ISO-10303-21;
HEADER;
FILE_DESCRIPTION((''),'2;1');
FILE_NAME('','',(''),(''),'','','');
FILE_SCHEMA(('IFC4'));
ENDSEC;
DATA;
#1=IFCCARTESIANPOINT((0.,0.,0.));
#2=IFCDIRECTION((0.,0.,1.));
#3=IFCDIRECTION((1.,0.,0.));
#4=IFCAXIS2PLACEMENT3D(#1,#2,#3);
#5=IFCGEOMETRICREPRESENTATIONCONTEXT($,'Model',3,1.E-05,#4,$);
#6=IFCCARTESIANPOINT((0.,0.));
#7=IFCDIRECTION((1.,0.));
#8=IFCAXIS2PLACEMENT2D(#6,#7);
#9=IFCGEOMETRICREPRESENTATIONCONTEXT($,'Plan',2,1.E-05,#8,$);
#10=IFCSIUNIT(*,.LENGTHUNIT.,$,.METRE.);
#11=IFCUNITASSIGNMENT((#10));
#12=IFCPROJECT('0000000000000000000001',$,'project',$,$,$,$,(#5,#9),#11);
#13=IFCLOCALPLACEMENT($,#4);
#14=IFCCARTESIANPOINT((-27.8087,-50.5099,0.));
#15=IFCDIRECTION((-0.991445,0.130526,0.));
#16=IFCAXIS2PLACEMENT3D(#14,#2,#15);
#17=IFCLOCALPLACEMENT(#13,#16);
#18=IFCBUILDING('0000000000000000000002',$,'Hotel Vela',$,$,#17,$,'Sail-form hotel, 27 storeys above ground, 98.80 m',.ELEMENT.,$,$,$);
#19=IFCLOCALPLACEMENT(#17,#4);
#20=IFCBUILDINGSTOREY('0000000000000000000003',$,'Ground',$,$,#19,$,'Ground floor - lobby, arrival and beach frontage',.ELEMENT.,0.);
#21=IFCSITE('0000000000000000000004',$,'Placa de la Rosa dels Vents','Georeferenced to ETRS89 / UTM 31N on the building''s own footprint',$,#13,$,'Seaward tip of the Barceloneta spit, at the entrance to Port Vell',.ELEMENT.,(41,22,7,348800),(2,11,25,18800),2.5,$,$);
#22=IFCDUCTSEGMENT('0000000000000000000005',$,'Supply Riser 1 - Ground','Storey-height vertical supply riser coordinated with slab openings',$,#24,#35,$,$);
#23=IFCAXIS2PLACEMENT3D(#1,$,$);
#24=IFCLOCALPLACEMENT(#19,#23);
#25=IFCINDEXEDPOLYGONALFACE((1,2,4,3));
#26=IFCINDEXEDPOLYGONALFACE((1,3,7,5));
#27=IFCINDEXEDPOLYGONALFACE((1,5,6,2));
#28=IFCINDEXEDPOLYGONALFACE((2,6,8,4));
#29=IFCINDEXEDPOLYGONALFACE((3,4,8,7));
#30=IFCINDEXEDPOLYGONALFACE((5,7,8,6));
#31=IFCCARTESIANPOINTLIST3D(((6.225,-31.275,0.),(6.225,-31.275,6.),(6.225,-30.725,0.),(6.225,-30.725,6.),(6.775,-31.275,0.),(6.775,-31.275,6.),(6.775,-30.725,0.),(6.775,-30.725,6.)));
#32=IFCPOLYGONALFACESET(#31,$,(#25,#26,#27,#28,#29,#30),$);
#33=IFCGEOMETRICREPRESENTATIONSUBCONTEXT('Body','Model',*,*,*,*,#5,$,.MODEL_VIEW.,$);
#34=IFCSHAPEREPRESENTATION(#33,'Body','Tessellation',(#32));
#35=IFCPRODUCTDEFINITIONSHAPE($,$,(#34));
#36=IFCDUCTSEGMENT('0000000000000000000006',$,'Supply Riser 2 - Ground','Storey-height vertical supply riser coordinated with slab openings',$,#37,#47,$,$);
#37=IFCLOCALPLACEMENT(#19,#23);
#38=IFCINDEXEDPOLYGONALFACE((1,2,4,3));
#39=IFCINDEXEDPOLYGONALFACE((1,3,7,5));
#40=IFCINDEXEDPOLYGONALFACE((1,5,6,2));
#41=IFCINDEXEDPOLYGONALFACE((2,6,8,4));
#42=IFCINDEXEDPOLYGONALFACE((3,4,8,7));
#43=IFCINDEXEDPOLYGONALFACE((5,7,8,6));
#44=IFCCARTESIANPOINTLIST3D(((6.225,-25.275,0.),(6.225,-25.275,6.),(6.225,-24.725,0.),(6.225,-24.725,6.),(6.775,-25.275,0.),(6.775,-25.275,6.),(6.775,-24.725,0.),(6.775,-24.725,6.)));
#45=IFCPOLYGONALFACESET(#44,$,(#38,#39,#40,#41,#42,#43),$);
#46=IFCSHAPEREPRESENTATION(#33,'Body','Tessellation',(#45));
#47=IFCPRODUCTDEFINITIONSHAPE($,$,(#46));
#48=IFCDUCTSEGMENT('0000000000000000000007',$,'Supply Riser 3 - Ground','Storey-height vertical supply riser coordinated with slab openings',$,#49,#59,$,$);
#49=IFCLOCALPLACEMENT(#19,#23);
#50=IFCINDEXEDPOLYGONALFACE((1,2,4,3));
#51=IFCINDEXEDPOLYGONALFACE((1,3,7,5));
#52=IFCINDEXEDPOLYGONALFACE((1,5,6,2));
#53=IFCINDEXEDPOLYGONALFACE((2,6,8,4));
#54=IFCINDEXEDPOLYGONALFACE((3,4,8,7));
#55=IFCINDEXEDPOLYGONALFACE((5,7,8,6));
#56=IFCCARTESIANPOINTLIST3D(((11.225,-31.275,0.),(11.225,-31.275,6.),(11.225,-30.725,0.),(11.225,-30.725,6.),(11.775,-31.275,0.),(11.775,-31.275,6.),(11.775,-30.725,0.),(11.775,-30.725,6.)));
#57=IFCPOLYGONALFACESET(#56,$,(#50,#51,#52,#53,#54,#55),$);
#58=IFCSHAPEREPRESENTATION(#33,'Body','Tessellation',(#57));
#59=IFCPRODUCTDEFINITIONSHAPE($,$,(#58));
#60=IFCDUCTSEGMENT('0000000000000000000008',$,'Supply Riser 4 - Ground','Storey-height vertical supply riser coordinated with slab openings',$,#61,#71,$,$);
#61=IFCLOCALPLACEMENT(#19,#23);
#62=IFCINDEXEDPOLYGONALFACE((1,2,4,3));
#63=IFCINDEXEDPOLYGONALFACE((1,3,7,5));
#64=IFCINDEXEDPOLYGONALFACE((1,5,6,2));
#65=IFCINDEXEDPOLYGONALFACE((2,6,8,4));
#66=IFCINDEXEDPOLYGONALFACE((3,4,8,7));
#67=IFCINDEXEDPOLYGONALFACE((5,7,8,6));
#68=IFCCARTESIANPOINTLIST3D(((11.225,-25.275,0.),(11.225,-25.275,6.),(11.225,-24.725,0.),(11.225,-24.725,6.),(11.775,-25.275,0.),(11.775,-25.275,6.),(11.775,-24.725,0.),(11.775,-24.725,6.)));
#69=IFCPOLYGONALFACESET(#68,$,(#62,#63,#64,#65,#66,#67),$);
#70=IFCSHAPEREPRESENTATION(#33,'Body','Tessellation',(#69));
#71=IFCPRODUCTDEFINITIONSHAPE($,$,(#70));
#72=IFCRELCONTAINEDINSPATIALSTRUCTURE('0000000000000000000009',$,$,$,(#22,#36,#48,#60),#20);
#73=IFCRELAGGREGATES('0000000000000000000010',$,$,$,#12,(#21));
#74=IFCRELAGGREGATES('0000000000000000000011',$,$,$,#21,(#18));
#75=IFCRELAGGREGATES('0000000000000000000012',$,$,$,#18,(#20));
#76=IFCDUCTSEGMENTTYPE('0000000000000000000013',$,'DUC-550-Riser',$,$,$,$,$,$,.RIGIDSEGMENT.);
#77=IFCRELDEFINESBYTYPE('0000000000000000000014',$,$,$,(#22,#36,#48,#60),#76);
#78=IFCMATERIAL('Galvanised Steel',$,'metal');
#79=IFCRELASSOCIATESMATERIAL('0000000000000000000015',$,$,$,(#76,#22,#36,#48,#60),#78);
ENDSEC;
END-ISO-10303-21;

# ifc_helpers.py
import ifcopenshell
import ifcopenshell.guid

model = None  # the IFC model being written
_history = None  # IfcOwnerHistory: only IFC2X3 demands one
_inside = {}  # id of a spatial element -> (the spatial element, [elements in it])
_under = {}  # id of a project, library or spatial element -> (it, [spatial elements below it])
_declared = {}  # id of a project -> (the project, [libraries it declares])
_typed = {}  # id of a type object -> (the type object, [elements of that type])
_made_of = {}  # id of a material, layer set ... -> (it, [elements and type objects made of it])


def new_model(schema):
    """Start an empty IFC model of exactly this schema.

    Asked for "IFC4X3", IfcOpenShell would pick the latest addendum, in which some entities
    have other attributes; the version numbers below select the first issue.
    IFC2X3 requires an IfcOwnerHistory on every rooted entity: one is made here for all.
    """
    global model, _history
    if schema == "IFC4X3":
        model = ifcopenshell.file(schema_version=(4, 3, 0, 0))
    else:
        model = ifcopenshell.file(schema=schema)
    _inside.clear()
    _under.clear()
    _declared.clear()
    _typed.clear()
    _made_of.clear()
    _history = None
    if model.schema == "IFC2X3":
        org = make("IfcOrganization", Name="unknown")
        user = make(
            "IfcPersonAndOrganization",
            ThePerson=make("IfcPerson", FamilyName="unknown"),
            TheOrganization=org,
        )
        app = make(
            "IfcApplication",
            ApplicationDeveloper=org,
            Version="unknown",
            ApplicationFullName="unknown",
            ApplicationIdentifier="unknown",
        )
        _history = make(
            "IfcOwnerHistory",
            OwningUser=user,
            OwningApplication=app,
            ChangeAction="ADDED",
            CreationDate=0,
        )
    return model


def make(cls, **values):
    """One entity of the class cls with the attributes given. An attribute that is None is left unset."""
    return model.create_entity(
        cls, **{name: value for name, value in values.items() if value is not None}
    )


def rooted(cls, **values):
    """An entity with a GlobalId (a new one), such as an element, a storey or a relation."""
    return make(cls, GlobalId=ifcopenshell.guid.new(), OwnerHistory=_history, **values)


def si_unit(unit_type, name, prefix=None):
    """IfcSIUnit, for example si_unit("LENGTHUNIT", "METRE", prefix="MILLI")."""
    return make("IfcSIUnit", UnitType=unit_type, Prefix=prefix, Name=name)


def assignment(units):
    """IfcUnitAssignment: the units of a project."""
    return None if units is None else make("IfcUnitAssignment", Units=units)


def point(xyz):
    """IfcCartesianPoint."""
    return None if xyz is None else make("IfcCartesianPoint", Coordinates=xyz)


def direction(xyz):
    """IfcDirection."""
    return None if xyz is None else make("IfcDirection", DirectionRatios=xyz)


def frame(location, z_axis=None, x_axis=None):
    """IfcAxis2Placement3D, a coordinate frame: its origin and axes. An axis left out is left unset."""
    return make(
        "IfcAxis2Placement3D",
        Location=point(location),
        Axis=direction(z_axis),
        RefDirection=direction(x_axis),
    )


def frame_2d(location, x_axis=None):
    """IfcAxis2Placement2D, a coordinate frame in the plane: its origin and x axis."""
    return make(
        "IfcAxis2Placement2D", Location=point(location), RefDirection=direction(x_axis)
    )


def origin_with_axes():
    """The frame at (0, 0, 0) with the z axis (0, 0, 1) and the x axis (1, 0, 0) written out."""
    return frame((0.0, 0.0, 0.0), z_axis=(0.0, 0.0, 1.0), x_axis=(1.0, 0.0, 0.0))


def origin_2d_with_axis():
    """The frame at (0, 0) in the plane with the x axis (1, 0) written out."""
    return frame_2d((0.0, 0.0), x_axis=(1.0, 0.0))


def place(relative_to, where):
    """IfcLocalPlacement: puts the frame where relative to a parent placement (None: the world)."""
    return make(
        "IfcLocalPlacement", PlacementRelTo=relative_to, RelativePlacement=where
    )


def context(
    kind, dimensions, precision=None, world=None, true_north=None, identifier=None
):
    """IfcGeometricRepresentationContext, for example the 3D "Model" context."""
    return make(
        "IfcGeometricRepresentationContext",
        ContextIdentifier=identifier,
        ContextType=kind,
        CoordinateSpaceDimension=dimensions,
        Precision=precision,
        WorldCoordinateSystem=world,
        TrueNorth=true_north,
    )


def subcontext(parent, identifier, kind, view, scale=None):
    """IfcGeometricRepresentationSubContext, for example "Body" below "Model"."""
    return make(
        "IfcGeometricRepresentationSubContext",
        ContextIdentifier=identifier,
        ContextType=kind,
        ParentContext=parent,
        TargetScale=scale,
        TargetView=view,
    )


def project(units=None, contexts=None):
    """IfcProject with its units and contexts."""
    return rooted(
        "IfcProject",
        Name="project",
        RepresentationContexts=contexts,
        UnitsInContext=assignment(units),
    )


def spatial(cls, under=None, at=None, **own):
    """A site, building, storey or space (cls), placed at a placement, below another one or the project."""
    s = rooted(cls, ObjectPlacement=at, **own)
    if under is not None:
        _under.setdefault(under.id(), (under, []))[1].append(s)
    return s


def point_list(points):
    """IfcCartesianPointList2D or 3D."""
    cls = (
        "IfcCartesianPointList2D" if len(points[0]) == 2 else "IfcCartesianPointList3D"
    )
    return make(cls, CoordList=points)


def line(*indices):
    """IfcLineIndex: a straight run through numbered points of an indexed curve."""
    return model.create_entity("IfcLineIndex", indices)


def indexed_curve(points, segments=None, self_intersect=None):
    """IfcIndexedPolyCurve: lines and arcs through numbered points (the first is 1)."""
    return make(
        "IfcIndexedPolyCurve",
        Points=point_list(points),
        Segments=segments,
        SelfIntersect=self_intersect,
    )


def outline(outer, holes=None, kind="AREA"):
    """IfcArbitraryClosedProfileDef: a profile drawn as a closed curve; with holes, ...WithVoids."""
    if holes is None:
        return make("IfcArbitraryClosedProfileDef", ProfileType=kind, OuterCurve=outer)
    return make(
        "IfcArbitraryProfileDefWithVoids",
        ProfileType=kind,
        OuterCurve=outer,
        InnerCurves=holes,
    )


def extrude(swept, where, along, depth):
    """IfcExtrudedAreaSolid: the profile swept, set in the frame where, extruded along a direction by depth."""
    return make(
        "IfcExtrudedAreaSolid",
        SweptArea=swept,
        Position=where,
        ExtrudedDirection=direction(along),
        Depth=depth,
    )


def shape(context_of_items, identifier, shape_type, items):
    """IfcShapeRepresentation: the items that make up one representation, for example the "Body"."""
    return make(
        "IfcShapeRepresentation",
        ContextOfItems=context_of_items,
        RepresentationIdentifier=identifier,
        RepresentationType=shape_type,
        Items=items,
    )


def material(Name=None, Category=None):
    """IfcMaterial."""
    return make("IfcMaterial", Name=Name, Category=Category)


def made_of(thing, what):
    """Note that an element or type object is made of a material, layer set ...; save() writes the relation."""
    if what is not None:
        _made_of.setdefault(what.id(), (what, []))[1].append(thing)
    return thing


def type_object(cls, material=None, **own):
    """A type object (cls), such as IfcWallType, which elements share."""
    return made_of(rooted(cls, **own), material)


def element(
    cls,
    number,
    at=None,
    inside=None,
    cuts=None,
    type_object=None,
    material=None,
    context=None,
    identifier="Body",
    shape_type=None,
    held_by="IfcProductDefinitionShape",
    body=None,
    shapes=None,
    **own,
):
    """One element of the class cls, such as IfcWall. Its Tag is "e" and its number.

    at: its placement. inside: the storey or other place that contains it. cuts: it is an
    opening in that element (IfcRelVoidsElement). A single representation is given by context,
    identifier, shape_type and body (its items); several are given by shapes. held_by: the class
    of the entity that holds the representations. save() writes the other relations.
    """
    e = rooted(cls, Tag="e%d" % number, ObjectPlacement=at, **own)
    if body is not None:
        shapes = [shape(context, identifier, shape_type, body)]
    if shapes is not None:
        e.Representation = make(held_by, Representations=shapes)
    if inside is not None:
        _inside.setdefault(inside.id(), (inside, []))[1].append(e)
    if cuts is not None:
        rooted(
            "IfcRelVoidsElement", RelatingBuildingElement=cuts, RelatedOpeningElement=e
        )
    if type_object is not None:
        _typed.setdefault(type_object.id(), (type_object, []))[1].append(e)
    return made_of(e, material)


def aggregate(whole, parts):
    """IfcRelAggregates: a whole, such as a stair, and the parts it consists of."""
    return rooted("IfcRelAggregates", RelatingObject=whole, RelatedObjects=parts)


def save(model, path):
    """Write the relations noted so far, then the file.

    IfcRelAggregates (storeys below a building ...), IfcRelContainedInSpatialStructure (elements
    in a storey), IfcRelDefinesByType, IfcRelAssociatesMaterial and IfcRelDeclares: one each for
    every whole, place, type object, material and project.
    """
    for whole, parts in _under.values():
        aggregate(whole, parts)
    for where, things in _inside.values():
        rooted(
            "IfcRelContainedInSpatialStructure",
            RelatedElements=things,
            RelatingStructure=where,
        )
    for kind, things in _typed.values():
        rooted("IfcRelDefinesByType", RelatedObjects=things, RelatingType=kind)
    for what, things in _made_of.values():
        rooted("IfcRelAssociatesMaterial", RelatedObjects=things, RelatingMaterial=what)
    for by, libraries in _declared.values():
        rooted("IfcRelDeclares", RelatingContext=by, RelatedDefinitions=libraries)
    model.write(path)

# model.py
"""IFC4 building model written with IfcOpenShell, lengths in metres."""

from ifc_helpers import new_model, si_unit, frame, origin_with_axes, origin_2d_with_axis, place, context, subcontext, project, spatial, line, indexed_curve, outline, extrude, material, type_object, element, save


model = new_model("IFC4")

# Units and contexts
model_context = context("Model", 3, precision=1e-05, world=origin_with_axes())
plan_context = context("Plan", 2, precision=1e-05, world=origin_2d_with_axis())
body_context = subcontext(model_context, "Body", "Model", "MODEL_VIEW")
ifc_project = project(units=[si_unit("LENGTHUNIT", "METRE")], contexts=[model_context, plan_context])

# Site, building, storey
site_placement = place(None, origin_with_axes())
site = spatial("IfcSite", under=ifc_project, at=site_placement, Name="Placa de la Rosa dels Vents", Description="Georeferenced to ETRS89 / UTM 31N on the building's own footprint", LongName="Seaward tip of the Barceloneta spit, at the entrance to Port Vell", CompositionType="ELEMENT", RefLatitude=(41, 22, 7, 348800), RefLongitude=(2, 11, 25, 18800), RefElevation=2.5)
building_placement = place(site_placement, frame((-27.8087, -50.5099, 0.0), z_axis=(0.0, 0.0, 1.0), x_axis=(-0.991445, 0.130526, 0.0)))
building = spatial("IfcBuilding", under=site, at=building_placement, Name="Hotel Vela", LongName="Sail-form hotel, 27 storeys above ground, 98.80 m", CompositionType="ELEMENT")
storey_placement = place(building_placement, origin_with_axes())
storey = spatial("IfcBuildingStorey", under=building, at=storey_placement, Name="Ground", LongName="Ground floor - lobby, arrival and beach frontage", CompositionType="ELEMENT", Elevation=0.0)

# Duct segments
ifc_material = material(Name="Galvanised Steel", Category="metal")
duct_segment_type = type_object("IfcDuctSegmentType", Name="DUC-550-Riser", PredefinedType="RIGIDSEGMENT", material=ifc_material)
for number, where, z_axis, x_axis, name in (
    (1, (6.225, -31.275, 0.0), (0.0, 0.0, 1.0), (1.0, 0.0, 0.0), "Supply Riser 1 - Ground"),
    (2, (6.225, -25.275, 0.0), (0.0, 0.0, 1.0), (1.0, 0.0, 0.0), "Supply Riser 2 - Ground"),
    (3, (11.225, -31.275, 0.0), (0.0, 0.0, 1.0), (1.0, 0.0, 0.0), "Supply Riser 3 - Ground"),
    (4, (11.225, -25.275, 0.0), (0.0, 0.0, 1.0), (1.0, 0.0, 0.0), "Supply Riser 4 - Ground"),
):
    element("IfcDuctSegment", number, at=place(storey_placement, frame(where, z_axis=z_axis, x_axis=x_axis)), inside=storey, type_object=duct_segment_type, material=ifc_material, Name=name, Description="Storey-height vertical supply riser coordinated with slab openings", context=body_context, shape_type="SweptSolid", body=[
        extrude(outline(indexed_curve([(0.0, 0.0), (0.55, 0.0), (0.55, 0.55), (0.0, 0.55)], segments=[line(1, 2, 3, 4, 1)])), origin_with_axes(), (0.0, 0.0, 1.0), 6.0),
    ])

save(model, "model.ifc")
